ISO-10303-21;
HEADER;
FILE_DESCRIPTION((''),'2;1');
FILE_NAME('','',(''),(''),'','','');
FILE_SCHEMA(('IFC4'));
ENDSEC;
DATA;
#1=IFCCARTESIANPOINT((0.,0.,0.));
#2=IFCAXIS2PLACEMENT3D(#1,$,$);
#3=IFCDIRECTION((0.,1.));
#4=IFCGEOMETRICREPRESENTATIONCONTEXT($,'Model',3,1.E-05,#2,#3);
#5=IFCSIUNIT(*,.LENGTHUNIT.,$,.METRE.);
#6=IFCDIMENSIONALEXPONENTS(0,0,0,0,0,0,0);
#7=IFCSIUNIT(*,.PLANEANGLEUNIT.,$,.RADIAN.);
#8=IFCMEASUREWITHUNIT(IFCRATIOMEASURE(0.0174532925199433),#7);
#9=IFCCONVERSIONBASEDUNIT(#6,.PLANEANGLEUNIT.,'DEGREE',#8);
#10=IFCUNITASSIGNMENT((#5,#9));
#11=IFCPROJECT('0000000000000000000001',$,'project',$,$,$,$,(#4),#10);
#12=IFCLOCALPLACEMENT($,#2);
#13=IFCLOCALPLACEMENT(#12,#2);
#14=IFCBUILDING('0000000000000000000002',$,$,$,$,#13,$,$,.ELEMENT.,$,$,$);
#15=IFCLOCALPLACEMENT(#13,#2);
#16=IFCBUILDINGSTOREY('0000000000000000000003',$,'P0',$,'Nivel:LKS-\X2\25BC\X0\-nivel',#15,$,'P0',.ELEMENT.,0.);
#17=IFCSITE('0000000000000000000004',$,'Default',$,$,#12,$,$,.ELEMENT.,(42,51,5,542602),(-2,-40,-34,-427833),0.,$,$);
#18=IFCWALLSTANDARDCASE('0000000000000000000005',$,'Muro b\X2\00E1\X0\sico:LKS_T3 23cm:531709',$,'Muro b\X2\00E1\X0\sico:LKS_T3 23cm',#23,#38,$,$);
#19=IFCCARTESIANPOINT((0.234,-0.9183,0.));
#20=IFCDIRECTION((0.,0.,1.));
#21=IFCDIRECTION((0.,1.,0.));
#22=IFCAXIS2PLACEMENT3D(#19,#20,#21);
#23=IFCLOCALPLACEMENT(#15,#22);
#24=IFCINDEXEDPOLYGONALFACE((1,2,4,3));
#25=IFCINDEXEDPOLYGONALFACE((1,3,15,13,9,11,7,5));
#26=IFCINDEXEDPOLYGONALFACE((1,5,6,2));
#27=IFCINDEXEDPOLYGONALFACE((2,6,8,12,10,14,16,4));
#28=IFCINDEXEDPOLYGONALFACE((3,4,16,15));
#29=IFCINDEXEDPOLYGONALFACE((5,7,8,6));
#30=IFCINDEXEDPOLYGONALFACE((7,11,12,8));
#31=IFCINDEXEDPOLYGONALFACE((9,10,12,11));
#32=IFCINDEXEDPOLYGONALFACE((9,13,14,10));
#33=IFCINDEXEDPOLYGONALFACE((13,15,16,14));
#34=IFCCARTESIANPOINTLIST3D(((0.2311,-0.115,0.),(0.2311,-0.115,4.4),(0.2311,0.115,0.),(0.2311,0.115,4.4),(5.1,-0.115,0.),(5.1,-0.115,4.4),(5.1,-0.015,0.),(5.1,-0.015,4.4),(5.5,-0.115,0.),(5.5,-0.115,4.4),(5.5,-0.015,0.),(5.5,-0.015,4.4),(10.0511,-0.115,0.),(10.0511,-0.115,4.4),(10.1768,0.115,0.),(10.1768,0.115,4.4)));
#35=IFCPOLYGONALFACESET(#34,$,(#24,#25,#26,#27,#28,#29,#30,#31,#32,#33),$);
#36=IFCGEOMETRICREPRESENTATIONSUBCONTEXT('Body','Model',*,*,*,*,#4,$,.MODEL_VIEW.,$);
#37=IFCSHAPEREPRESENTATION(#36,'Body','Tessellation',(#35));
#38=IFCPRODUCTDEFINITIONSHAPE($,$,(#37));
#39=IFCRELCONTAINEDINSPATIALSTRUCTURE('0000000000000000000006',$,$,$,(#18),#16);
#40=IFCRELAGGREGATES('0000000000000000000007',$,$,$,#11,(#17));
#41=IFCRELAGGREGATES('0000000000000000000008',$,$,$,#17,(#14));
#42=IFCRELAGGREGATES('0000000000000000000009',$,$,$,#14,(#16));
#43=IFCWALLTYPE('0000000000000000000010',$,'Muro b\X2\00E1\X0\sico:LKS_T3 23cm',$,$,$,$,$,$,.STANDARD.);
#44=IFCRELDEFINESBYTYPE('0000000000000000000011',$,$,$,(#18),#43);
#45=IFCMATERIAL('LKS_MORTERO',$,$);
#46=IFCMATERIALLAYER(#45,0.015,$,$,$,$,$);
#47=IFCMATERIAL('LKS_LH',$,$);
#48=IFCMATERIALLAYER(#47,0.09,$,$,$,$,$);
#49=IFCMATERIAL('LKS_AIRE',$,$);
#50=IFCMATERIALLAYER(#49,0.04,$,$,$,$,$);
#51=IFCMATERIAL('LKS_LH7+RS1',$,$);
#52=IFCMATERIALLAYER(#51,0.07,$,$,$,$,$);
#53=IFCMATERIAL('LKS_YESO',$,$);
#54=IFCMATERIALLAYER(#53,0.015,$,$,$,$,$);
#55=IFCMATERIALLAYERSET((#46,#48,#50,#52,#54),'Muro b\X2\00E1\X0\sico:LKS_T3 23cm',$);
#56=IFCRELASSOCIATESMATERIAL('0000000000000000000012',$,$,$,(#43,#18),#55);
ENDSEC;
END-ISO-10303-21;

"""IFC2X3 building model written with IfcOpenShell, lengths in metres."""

from ifc_helpers import new_model, entity, si_unit, converted_unit, direction, frame, origin, place, context, subcontext, project, spatial, polyline, outline, extrude, clip, bounded_halfspace, material, layer, layer_set, layer_usage, type_object, element, save


model = new_model("IFC2X3")

# Units and contexts
model_context = context("Model", 3, precision=1e-05, world=origin(), true_north=direction((0.0, 1.0)))
body_context = subcontext(model_context, "Body", "Model", "MODEL_VIEW")
ifc_project = project(units=[si_unit("LENGTHUNIT", "METRE"), converted_unit("PLANEANGLEUNIT", "DEGREE", entity("IfcRatioMeasure", 0.0174532925199433), si_unit("PLANEANGLEUNIT", "RADIAN"), dimensions=[0, 0, 0, 0, 0, 0, 0])], contexts=[model_context])

# Site, building, storey
site_placement = place(None, origin())
site = spatial("IfcSite", under=ifc_project, at=site_placement, Name="Default", CompositionType="ELEMENT", RefLatitude=(42, 51, 5, 542602), RefLongitude=(-2, -40, -34, -427833), RefElevation=0.0)
building_placement = place(site_placement, origin())
building = spatial("IfcBuilding", under=site, at=building_placement, CompositionType="ELEMENT")
storey_placement = place(building_placement, origin())
storey = spatial("IfcBuildingStorey", under=building, at=storey_placement, Name="P0", ObjectType="Nivel:LKS-▼-nivel", LongName="P0", CompositionType="ELEMENT", Elevation=0.0)

# Shared definitions
ifc_material_1 = material(Name="LKS_MORTERO")
ifc_layer_1 = layer(ifc_material_1, 0.015)
ifc_material_2 = material(Name="LKS_LH")
ifc_layer_2 = layer(ifc_material_2, 0.09)
ifc_material_3 = material(Name="LKS_AIRE")
ifc_layer_3 = layer(ifc_material_3, 0.04)
ifc_material_4 = material(Name="LKS_LH7+RS1")
ifc_layer_4 = layer(ifc_material_4, 0.07)
ifc_material_5 = material(Name="LKS_YESO")
ifc_layer_5 = layer(ifc_material_5, 0.015)
ifc_layer_set_1 = layer_set([ifc_layer_1, ifc_layer_2, ifc_layer_3, ifc_layer_4, ifc_layer_5], Name="Muro básico:LKS_T3 23cm")
wall_type_1 = type_object("IfcWallType", Name="Muro básico:LKS_T3 23cm", PredefinedType="STANDARD", material=ifc_layer_set_1)

# Wall
ifc_layer_usage_1 = layer_usage(ifc_layer_set_1, "AXIS2", "NEGATIVE", 0.115)
wall_1_placement = place(storey_placement, frame((0.234, -0.9183, 0.0), z_axis=(0.0, 0.0, 1.0), x_axis=(0.0, 1.0, 0.0)))
element("IfcWallStandardCase", 1, at=wall_1_placement, inside=storey, type_object=wall_type_1, material=ifc_layer_usage_1, Name="Muro básico:LKS_T3 23cm:531709", ObjectType="Muro básico:LKS_T3 23cm", context=body_context, shape_type="Clipping", body=[
    clip(extrude(outline(polyline([(0.2311, 0.115), (0.2311, -0.115), (5.1, -0.115), (5.1, -0.015), (5.5, -0.015), (5.5, -0.115), (10.0511, -0.115), (10.1768, 0.115), (0.2311, 0.115)])), origin(), (0.0, 0.0, 1.0), 4.4), bounded_halfspace(frame((5.1, -0.015, 4.4), z_axis=(0.0, 1.0, 0.0), x_axis=(0.0, 0.0, -1.0)), True, frame((5.1, -0.015, 4.4), z_axis=(0.0, 1.0, 0.0), x_axis=(0.0, 0.0, -1.0)), polyline([(0.0, 0.0), (0.0, -0.4), (4.4, -0.4), (4.4, 0.0), (0.0, 0.0)]))),
])

save(model, "model.ifc")
